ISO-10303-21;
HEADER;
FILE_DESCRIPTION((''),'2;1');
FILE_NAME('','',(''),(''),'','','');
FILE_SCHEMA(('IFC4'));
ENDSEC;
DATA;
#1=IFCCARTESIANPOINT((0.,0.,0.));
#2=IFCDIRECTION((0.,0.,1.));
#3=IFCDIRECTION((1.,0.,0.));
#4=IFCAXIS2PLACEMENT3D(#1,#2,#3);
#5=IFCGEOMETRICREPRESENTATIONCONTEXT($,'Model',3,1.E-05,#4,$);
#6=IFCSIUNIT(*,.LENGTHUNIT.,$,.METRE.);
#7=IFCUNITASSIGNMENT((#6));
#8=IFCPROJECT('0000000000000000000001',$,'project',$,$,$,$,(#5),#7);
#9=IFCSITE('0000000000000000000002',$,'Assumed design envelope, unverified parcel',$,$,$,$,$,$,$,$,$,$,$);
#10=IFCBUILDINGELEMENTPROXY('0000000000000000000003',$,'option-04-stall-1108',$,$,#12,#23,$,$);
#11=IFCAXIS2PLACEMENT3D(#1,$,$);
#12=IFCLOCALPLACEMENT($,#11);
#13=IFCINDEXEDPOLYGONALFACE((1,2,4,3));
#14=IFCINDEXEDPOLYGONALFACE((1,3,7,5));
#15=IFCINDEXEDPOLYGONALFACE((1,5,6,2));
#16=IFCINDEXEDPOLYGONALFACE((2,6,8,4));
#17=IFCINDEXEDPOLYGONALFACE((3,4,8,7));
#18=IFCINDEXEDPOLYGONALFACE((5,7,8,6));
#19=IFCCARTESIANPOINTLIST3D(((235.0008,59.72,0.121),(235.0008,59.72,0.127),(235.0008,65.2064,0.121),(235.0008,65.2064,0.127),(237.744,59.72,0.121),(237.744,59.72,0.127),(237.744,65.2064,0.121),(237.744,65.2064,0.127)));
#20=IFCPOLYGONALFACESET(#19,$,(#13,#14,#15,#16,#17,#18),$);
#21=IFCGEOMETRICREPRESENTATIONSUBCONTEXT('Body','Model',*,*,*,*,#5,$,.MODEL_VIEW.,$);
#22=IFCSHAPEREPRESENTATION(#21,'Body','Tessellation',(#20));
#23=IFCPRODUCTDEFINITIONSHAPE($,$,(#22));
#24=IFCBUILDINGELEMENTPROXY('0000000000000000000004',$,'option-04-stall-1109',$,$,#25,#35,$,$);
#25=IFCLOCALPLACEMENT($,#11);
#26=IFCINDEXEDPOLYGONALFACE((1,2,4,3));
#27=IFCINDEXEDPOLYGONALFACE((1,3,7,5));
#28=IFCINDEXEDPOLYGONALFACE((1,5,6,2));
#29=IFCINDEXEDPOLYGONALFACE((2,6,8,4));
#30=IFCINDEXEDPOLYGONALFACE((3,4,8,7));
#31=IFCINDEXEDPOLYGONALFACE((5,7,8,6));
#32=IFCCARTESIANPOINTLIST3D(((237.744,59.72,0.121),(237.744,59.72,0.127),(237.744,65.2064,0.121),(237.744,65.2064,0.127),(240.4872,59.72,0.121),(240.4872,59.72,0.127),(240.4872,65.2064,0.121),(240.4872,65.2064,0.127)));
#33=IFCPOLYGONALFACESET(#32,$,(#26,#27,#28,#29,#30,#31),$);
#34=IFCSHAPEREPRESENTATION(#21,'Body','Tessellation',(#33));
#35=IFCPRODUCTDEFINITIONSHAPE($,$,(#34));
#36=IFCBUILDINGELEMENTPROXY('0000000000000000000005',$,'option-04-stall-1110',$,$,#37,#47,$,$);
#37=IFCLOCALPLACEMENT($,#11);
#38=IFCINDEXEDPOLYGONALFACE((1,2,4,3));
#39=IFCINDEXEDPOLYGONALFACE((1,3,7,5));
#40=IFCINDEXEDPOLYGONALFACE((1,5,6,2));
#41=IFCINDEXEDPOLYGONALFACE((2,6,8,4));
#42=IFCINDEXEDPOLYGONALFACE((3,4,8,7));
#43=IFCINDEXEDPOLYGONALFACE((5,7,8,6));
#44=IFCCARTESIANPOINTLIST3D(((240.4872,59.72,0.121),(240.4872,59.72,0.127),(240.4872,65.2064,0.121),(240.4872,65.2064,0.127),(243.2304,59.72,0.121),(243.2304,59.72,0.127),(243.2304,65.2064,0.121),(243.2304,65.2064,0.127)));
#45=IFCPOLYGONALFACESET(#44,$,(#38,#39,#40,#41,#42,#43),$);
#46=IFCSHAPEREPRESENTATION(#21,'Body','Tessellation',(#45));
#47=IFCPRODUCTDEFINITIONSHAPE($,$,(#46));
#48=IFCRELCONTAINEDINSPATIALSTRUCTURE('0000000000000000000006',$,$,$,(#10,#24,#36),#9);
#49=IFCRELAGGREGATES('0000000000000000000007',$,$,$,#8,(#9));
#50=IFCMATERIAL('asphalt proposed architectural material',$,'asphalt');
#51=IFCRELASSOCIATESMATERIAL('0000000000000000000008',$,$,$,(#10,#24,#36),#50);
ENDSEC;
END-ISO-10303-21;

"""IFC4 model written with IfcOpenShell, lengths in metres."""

from ifc_helpers import new_model, si_unit, frame, origin_with_axes, place, context, subcontext, project, spatial, rectangle, extrude, material, element, save


model = new_model("IFC4")

# Units and contexts
model_context = context("Model", 3, precision=1e-05, world=origin_with_axes())
body_context = subcontext(model_context, "Body", "Model", "MODEL_VIEW")
ifc_project = project(units=[si_unit("LENGTHUNIT", "METRE")], contexts=[model_context])

# Site
site = spatial("IfcSite", under=ifc_project, Name="Assumed design envelope, unverified parcel")

# Building element proxies
ifc_material = material(Name="asphalt proposed architectural material", Category="asphalt")
for number, where, z_axis, x_axis, name in (
    (1, (236.3724, 62.4632, 0.121), (0.0, 0.0, 1.0), (1.0, 0.0, 0.0), "option-04-stall-1108"),
    (2, (239.1156, 62.4632, 0.121), (0.0, 0.0, 1.0), (1.0, 0.0, 0.0), "option-04-stall-1109"),
    (3, (241.8588, 62.4632, 0.121), (0.0, 0.0, 1.0), (1.0, 0.0, 0.0), "option-04-stall-1110"),
):
    element("IfcBuildingElementProxy", number, at=place(None, frame(where, z_axis=z_axis, x_axis=x_axis)), inside=site, material=ifc_material, Name=name, context=body_context, shape_type="SweptSolid", body=[
        extrude(rectangle(XDim=2.7432, YDim=5.4864), origin_with_axes(), (0.0, 0.0, 1.0), 0.006),
    ])

save(model, "model.ifc")
